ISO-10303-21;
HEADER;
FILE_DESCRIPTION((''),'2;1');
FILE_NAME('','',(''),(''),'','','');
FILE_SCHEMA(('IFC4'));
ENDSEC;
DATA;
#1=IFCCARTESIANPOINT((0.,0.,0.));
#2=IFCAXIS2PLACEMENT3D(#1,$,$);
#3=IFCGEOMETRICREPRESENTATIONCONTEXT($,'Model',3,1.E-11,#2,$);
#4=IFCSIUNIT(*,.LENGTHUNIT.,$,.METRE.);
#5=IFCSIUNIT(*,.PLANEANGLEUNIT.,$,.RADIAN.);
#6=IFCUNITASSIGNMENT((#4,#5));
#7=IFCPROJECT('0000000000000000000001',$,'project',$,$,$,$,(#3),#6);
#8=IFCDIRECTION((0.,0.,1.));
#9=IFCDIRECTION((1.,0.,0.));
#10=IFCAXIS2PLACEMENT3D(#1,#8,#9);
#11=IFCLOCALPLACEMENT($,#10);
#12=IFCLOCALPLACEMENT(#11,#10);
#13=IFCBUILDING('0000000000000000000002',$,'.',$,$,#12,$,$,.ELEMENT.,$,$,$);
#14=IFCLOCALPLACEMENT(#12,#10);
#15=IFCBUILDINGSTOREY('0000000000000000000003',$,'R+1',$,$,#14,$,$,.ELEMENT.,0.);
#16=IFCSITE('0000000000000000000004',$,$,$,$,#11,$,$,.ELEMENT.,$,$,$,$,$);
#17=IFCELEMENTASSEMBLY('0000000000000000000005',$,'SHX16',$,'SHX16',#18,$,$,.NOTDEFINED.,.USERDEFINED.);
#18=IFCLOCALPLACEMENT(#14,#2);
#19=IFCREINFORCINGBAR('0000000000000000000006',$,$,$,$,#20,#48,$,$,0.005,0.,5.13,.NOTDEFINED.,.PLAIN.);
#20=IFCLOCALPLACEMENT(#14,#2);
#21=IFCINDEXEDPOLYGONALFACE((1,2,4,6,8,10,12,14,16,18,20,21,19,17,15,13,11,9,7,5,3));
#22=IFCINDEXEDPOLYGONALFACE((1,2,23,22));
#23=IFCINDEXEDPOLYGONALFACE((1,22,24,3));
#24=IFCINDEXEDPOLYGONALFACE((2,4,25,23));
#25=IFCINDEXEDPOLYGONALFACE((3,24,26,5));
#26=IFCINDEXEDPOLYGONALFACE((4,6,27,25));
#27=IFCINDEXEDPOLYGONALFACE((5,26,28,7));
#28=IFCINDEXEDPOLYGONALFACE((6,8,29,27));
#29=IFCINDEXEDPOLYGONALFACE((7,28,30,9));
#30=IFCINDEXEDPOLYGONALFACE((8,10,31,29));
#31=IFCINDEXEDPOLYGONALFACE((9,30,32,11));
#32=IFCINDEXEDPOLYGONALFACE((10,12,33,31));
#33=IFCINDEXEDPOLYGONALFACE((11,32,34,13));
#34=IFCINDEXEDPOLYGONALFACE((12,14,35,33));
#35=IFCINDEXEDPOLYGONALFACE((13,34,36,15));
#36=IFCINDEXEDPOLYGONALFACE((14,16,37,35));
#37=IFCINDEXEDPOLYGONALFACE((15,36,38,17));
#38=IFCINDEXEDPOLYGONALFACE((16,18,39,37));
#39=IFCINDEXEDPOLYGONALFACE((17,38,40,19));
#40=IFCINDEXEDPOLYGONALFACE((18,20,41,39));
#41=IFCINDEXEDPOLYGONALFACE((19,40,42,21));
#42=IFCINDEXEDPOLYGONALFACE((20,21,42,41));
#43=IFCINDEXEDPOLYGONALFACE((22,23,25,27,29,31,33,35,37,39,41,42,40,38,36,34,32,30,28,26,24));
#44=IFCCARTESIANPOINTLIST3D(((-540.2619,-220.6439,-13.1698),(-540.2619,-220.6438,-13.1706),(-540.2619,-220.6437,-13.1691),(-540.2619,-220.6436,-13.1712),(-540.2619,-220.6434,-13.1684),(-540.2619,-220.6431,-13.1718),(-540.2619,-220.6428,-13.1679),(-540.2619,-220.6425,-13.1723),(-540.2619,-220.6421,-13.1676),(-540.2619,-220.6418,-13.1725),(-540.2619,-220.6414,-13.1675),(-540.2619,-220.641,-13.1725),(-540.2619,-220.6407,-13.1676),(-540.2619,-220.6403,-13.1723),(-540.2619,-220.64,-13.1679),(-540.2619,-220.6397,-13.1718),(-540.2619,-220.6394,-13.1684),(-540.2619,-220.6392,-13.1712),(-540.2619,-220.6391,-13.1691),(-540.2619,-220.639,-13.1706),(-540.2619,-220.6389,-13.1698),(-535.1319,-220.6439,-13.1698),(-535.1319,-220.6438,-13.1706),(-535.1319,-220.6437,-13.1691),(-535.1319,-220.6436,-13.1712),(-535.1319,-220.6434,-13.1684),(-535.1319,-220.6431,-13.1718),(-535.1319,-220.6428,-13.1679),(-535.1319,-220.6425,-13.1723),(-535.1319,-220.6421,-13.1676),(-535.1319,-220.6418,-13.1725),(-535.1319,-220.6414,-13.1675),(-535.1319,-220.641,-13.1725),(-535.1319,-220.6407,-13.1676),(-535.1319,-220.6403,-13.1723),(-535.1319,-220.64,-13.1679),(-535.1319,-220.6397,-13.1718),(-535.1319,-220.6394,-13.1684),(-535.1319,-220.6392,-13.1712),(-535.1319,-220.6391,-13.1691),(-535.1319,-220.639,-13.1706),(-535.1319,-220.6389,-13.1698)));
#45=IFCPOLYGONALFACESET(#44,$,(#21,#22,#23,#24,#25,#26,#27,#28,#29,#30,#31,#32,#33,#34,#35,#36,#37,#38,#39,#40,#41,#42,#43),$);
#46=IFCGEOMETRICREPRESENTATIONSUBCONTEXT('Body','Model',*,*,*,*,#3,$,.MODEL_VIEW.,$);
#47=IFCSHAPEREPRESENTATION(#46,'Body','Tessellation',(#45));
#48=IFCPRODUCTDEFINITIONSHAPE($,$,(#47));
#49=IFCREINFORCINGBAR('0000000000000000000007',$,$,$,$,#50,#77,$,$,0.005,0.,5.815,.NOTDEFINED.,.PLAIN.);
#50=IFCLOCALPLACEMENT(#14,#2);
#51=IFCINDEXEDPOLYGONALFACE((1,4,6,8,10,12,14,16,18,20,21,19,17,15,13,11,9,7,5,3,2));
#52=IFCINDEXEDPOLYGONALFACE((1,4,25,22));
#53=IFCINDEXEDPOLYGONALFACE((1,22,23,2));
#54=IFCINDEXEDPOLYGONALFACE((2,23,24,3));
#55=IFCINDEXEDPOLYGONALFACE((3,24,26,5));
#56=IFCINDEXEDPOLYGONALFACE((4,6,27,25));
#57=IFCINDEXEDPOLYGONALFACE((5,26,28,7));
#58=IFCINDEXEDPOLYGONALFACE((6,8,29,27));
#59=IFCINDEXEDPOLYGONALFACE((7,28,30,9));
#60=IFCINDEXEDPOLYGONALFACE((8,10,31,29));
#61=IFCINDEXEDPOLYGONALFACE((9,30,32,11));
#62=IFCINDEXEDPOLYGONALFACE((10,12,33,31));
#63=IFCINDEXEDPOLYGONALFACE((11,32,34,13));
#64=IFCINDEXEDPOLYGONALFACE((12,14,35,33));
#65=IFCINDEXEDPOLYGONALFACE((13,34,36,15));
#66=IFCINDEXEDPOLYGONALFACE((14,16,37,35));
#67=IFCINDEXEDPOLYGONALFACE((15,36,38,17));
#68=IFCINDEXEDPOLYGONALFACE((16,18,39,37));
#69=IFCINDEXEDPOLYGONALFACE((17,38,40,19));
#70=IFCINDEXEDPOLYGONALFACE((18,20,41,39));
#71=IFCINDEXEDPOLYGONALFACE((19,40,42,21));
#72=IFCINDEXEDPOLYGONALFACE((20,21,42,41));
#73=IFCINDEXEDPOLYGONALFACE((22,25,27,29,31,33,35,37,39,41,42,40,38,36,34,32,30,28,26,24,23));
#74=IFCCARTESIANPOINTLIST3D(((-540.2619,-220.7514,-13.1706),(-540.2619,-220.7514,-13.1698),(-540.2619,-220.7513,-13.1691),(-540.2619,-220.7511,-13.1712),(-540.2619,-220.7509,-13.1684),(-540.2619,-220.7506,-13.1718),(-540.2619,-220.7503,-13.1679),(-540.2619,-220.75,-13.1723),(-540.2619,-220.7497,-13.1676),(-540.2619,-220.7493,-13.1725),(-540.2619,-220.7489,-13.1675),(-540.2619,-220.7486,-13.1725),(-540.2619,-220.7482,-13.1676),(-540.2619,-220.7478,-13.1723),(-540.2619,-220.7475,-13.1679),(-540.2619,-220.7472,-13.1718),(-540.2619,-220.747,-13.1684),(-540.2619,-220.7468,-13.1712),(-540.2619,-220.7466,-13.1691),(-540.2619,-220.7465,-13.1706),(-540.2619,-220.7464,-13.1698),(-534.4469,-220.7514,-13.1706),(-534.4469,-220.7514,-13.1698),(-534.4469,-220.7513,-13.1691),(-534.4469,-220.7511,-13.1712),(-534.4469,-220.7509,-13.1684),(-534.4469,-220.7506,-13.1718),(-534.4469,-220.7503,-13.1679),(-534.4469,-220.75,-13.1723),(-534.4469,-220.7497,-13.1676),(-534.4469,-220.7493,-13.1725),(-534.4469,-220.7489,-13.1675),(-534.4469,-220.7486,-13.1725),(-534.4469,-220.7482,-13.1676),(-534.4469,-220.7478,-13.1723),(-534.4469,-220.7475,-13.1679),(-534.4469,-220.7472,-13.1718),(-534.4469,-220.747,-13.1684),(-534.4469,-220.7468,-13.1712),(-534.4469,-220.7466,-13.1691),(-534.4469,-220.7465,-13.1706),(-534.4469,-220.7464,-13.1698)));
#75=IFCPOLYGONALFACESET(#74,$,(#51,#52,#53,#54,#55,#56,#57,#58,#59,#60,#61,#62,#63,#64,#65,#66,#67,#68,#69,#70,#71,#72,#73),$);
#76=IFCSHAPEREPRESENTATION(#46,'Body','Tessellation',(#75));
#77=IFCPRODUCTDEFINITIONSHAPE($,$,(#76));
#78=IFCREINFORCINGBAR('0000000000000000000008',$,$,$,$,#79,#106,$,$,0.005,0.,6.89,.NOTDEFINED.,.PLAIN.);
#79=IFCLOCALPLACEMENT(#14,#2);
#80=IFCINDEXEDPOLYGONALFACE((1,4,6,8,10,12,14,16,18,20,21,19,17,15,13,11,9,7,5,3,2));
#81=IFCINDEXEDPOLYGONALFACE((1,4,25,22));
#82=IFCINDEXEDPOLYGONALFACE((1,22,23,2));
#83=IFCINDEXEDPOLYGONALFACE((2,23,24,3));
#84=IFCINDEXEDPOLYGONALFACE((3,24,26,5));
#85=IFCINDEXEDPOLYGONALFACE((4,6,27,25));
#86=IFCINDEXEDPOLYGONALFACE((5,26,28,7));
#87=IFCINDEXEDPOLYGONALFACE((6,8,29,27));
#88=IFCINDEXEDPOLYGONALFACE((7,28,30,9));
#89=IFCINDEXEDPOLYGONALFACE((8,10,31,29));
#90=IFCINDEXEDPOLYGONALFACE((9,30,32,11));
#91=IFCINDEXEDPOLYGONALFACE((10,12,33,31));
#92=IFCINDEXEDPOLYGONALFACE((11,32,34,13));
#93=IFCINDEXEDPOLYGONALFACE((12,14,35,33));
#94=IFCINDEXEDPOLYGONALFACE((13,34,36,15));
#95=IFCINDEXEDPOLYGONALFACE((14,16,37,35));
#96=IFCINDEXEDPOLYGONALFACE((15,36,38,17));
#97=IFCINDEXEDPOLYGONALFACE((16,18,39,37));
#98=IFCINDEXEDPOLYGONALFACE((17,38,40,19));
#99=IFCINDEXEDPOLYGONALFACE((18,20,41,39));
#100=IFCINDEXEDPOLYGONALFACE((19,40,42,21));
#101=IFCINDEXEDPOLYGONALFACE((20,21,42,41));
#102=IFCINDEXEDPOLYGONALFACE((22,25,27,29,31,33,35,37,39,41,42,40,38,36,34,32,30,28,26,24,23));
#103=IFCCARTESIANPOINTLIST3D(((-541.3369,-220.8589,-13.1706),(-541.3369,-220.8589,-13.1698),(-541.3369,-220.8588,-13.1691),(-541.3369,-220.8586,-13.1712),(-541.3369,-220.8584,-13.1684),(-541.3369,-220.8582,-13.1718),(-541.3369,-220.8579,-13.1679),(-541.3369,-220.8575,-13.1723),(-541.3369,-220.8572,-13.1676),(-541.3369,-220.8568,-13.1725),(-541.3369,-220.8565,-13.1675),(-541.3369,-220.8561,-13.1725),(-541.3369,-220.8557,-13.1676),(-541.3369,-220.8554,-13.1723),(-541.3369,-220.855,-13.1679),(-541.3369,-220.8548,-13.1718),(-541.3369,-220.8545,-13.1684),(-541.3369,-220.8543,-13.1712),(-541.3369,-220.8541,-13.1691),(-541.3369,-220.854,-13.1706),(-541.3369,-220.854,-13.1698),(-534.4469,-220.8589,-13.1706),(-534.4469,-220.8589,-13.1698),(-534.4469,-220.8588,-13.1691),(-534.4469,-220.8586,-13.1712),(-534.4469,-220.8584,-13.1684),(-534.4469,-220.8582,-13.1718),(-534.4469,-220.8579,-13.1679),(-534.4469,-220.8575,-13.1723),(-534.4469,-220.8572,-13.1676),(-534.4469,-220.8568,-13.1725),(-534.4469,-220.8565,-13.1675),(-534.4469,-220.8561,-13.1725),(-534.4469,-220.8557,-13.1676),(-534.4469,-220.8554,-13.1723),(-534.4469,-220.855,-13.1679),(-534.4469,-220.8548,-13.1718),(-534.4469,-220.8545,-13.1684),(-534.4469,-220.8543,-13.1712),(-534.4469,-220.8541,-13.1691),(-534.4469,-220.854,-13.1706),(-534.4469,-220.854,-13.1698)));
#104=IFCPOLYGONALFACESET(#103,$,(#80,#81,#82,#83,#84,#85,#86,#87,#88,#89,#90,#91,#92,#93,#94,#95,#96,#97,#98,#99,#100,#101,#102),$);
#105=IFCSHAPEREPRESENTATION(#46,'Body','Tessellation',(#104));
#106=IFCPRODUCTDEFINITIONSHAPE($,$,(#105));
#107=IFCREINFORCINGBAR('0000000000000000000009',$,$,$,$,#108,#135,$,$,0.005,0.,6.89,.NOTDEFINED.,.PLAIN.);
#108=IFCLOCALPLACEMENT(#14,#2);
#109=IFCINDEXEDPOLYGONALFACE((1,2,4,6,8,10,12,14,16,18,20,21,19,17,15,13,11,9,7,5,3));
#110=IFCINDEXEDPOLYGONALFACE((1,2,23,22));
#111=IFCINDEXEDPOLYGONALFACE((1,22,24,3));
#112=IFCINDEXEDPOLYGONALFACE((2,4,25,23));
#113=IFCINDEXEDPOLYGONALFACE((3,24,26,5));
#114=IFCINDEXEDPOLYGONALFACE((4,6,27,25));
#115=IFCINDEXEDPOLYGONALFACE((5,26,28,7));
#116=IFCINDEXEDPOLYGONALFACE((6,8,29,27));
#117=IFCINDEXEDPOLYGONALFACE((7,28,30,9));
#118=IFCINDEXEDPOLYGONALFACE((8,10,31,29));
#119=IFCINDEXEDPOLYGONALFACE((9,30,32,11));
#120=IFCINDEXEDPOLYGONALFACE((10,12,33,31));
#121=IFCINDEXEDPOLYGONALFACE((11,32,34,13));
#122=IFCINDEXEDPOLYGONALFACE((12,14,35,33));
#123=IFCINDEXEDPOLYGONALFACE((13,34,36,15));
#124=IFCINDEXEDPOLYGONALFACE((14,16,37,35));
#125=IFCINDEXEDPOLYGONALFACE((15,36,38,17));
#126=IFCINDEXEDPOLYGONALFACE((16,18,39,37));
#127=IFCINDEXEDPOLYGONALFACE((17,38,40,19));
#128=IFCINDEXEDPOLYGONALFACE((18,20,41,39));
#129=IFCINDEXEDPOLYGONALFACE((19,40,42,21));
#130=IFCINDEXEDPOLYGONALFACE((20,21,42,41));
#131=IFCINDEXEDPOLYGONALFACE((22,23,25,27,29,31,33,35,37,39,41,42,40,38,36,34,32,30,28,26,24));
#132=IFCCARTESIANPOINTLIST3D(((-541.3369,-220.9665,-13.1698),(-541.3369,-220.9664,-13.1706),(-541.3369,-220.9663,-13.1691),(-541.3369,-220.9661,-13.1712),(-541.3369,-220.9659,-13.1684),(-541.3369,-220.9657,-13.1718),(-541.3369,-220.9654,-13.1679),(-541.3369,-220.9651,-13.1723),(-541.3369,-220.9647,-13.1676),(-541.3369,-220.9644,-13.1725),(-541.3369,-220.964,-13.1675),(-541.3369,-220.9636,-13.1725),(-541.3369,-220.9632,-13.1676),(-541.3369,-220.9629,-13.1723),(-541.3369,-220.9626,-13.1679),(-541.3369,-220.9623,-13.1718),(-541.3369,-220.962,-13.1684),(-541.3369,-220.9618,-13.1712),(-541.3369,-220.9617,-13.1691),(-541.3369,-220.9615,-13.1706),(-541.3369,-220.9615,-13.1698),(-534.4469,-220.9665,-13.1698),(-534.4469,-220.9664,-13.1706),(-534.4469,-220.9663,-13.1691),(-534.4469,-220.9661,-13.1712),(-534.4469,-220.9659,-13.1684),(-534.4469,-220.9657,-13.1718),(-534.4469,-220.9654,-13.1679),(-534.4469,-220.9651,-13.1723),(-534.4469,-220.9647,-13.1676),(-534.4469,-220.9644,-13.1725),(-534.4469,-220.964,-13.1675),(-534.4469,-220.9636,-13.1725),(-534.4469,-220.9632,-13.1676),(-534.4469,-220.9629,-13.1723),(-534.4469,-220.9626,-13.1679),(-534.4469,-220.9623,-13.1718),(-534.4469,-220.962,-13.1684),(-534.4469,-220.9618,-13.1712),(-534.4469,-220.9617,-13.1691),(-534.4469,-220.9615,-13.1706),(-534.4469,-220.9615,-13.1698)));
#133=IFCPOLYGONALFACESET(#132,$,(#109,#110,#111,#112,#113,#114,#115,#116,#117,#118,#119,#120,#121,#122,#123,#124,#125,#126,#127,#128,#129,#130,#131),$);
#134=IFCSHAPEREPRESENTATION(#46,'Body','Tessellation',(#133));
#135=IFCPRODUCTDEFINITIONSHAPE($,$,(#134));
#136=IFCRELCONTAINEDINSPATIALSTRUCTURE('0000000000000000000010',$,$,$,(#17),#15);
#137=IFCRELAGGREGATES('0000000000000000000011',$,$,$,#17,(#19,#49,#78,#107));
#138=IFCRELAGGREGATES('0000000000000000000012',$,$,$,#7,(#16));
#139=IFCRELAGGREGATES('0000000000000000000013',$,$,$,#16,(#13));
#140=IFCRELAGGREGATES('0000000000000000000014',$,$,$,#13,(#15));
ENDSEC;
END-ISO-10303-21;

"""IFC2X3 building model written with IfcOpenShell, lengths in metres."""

from ifc_helpers import new_model, entity, si_unit, origin, origin_with_axes, place, context, subcontext, project, spatial, shape, element, aggregate, save


model = new_model("IFC2X3")

# Units and contexts
model_context = context("Model", 3, precision=1e-11, world=origin())
body_context = subcontext(model_context, "Body", "Model", "MODEL_VIEW")
ifc_project = project(units=[si_unit("LENGTHUNIT", "METRE"), si_unit("PLANEANGLEUNIT", "RADIAN")], contexts=[model_context])

# Site, building, storey
site_placement = place(None, origin_with_axes())
site = spatial("IfcSite", under=ifc_project, at=site_placement, CompositionType="ELEMENT")
building_placement = place(site_placement, origin_with_axes())
building = spatial("IfcBuilding", under=site, at=building_placement, Name=".", CompositionType="ELEMENT")
storey_placement = place(building_placement, origin_with_axes())
storey = spatial("IfcBuildingStorey", under=building, at=storey_placement, Name="R+1", CompositionType="ELEMENT", Elevation=0.0)

# Element assembly, reinforcing bars
assembly_1_placement = place(storey_placement, origin_with_axes())
assembly_1 = element("IfcElementAssembly", 1, at=assembly_1_placement, inside=storey, Name="SHX16", ObjectType="SHX16", AssemblyPlace="NOTDEFINED", PredefinedType="USERDEFINED")
reinforcing_bar_1_placement = place(assembly_1_placement, origin_with_axes())
reinforcing_bar_1 = element("IfcReinforcingBar", 2, at=reinforcing_bar_1_placement, BarLength=5.13, BarRole="NOTDEFINED", BarSurface="PLAIN", CrossSectionArea=0.0, NominalDiameter=0.005, shapes=[
    shape(body_context, "Body", "AdvancedSweptSolid", [entity("IfcSweptDiskSolid", entity("IfcPolyline", [entity("IfcCartesianPoint", [535.1319, 220.6414, 13.17]), entity("IfcCartesianPoint", [540.2619, 220.6414, 13.17])]), 0.0025, None, 0.0, 5.13)]),
    shape(body_context, "Body", "AdvancedSweptSolid", [entity("IfcSweptDiskSolid", entity("IfcPolyline", [entity("IfcCartesianPoint", [535.1319, 220.6414, 13.17]), entity("IfcCartesianPoint", [540.2619, 220.6414, 13.17])]), 0.0025, None, 0.0, 5.13)]),
])
reinforcing_bar_2_placement = place(assembly_1_placement, origin_with_axes())
reinforcing_bar_2 = element("IfcReinforcingBar", 3, at=reinforcing_bar_2_placement, BarLength=5.815, BarRole="NOTDEFINED", BarSurface="PLAIN", CrossSectionArea=0.0, NominalDiameter=0.005, shapes=[
    shape(body_context, "Body", "AdvancedSweptSolid", [entity("IfcSweptDiskSolid", entity("IfcPolyline", [entity("IfcCartesianPoint", [534.4469, 220.7489, 13.17]), entity("IfcCartesianPoint", [540.2619, 220.7489, 13.17])]), 0.0025, None, 0.0, 5.815)]),
    shape(body_context, "Body", "AdvancedSweptSolid", [entity("IfcSweptDiskSolid", entity("IfcPolyline", [entity("IfcCartesianPoint", [534.4469, 220.7489, 13.17]), entity("IfcCartesianPoint", [540.2619, 220.7489, 13.17])]), 0.0025, None, 0.0, 5.815)]),
])
reinforcing_bar_3_placement = place(assembly_1_placement, origin_with_axes())
reinforcing_bar_3 = element("IfcReinforcingBar", 4, at=reinforcing_bar_3_placement, BarLength=6.89, BarRole="NOTDEFINED", BarSurface="PLAIN", CrossSectionArea=0.0, NominalDiameter=0.005, shapes=[
    shape(body_context, "Body", "AdvancedSweptSolid", [entity("IfcSweptDiskSolid", entity("IfcPolyline", [entity("IfcCartesianPoint", [534.4469, 220.8565, 13.17]), entity("IfcCartesianPoint", [541.3369, 220.8565, 13.17])]), 0.0025, None, 0.0, 6.89)]),
    shape(body_context, "Body", "AdvancedSweptSolid", [entity("IfcSweptDiskSolid", entity("IfcPolyline", [entity("IfcCartesianPoint", [534.4469, 220.8565, 13.17]), entity("IfcCartesianPoint", [541.3369, 220.8565, 13.17])]), 0.0025, None, 0.0, 6.89)]),
])
reinforcing_bar_4_placement = place(assembly_1_placement, origin_with_axes())
reinforcing_bar_4 = element("IfcReinforcingBar", 5, at=reinforcing_bar_4_placement, BarLength=6.89, BarRole="NOTDEFINED", BarSurface="PLAIN", CrossSectionArea=0.0, NominalDiameter=0.005, shapes=[
    shape(body_context, "Body", "AdvancedSweptSolid", [entity("IfcSweptDiskSolid", entity("IfcPolyline", [entity("IfcCartesianPoint", [534.4469, 220.964, 13.17]), entity("IfcCartesianPoint", [541.3369, 220.964, 13.17])]), 0.0025, None, 0.0, 6.89)]),
    shape(body_context, "Body", "AdvancedSweptSolid", [entity("IfcSweptDiskSolid", entity("IfcPolyline", [entity("IfcCartesianPoint", [534.4469, 220.964, 13.17]), entity("IfcCartesianPoint", [541.3369, 220.964, 13.17])]), 0.0025, None, 0.0, 6.89)]),
])
aggregate(assembly_1, [reinforcing_bar_1, reinforcing_bar_2, reinforcing_bar_3, reinforcing_bar_4])

save(model, "model.ifc")
